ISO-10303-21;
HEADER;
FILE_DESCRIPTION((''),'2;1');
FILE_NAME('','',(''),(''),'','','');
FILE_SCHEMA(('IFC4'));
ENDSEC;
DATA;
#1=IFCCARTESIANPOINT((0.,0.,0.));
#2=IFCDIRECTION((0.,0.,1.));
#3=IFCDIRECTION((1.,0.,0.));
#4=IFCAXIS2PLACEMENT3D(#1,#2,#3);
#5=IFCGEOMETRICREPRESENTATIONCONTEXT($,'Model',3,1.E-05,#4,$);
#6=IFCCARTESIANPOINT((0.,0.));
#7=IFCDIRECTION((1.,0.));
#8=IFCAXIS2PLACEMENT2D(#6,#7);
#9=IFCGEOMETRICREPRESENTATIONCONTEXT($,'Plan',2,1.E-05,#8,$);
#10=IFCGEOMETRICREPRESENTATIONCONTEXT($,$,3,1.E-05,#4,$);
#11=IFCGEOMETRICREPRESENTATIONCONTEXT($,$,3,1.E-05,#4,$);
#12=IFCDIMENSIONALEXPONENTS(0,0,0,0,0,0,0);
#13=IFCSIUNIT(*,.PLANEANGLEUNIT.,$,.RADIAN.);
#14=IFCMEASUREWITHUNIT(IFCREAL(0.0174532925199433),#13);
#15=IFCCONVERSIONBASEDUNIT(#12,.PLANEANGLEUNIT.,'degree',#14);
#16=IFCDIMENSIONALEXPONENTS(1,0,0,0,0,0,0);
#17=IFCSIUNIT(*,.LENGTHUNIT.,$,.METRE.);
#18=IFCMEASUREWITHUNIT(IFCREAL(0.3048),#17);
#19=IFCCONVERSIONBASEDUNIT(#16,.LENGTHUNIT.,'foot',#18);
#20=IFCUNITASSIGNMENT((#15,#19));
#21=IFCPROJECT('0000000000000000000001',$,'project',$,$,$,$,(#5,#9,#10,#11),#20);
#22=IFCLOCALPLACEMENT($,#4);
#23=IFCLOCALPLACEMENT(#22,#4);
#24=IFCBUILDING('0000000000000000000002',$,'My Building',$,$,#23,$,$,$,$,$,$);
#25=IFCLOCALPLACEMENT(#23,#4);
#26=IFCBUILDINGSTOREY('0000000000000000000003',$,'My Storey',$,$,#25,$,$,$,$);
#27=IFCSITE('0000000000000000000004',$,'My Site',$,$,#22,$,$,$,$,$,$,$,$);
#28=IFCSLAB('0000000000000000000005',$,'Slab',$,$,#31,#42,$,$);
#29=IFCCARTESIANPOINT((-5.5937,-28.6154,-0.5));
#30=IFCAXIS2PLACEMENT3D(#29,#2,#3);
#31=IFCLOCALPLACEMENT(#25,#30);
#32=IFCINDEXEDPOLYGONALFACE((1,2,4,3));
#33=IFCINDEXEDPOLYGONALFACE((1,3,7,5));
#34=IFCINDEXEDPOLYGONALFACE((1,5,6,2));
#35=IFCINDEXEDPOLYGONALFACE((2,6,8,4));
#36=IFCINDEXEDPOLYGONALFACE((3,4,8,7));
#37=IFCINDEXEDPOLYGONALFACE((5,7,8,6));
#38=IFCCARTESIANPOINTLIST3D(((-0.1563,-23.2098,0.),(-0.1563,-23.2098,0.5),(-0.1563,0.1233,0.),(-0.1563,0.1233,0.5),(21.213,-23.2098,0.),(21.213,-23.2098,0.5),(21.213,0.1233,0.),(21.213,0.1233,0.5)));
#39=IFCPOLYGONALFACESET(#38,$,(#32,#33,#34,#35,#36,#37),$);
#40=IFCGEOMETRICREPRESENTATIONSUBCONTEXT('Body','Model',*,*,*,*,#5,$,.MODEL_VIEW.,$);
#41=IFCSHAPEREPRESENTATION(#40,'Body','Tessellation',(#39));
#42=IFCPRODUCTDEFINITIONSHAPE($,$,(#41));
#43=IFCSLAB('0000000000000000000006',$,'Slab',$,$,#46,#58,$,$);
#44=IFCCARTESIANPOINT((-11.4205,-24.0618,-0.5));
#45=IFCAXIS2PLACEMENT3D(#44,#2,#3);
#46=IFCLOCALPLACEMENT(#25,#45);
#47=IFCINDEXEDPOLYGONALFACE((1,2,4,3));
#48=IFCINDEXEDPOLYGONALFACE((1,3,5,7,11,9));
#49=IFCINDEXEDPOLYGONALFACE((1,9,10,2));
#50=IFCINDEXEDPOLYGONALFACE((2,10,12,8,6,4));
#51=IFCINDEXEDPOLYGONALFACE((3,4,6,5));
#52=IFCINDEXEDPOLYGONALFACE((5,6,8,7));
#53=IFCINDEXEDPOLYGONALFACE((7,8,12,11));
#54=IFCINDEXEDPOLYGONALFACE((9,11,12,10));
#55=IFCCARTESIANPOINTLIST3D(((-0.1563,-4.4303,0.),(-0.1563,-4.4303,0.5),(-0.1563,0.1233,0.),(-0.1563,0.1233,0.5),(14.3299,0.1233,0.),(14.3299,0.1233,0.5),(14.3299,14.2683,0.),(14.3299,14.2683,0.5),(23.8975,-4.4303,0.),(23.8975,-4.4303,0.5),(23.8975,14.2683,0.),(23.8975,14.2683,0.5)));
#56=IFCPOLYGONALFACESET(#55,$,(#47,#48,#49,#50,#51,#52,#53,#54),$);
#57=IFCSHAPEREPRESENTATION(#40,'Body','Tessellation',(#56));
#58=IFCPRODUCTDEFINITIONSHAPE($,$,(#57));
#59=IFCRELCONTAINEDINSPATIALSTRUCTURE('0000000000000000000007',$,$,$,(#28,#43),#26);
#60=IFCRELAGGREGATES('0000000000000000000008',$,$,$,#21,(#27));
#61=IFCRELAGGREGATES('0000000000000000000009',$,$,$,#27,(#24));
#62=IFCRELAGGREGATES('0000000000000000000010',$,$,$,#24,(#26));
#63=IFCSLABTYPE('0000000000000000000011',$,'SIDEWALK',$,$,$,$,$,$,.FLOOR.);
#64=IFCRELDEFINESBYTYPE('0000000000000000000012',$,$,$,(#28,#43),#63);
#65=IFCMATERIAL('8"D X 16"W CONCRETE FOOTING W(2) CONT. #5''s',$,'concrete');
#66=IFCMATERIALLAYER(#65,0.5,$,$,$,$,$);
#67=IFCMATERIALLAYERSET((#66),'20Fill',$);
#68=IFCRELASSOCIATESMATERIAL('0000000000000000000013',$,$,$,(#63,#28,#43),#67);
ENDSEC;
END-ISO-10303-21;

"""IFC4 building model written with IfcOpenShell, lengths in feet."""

from ifc_helpers import new_model, entity, si_unit, converted_unit, frame, origin_with_axes, origin_2d_with_axis, place, context, subcontext, project, spatial, line, indexed_curve, outline, extrude, material, layer, layer_set, layer_usage, type_object, element, save


model = new_model("IFC4")

# Units and contexts
model_context = context("Model", 3, precision=1e-05, world=origin_with_axes())
plan_context = context("Plan", 2, precision=1e-05, world=origin_2d_with_axis())
context_of_model_1 = context(None, 3, precision=1e-05, world=origin_with_axes())
context_of_model_2 = context(None, 3, precision=1e-05, world=origin_with_axes())
body_context = subcontext(model_context, "Body", "Model", "MODEL_VIEW")
ifc_project = project(units=[converted_unit("PLANEANGLEUNIT", "degree", entity("IfcReal", 0.0174532925199433), si_unit("PLANEANGLEUNIT", "RADIAN"), dimensions=[0, 0, 0, 0, 0, 0, 0]), converted_unit("LENGTHUNIT", "foot", entity("IfcReal", 0.3048), si_unit("LENGTHUNIT", "METRE"), dimensions=[1, 0, 0, 0, 0, 0, 0])], contexts=[model_context, plan_context, context_of_model_1, context_of_model_2])

# Site, building, storey
site_placement = place(None, origin_with_axes())
site = spatial("IfcSite", under=ifc_project, at=site_placement, Name="My Site")
building_placement = place(site_placement, origin_with_axes())
building = spatial("IfcBuilding", under=site, at=building_placement, Name="My Building")
storey_placement = place(building_placement, origin_with_axes())
storey = spatial("IfcBuildingStorey", under=building, at=storey_placement, Name="My Storey")

# Slabs
ifc_material_1 = material(Name="8\"D X 16\"W CONCRETE FOOTING W(2) CONT. #5's", Category="concrete")
ifc_layer_1 = layer(ifc_material_1, 0.5)
ifc_layer_set_1 = layer_set([ifc_layer_1], Name="20Fill")
ifc_layer_usage_1 = layer_usage(ifc_layer_set_1, "AXIS3", "POSITIVE", 0.0)
slab_type_1 = type_object("IfcSlabType", Name="SIDEWALK", PredefinedType="FLOOR", material=ifc_layer_set_1)
slab_1_placement = place(storey_placement, frame((-5.5937, -28.6154, -0.5), z_axis=(0.0, 0.0, 1.0), x_axis=(1.0, 0.0, 0.0)))
element("IfcSlab", 1, at=slab_1_placement, inside=storey, type_object=slab_type_1, material=ifc_layer_usage_1, Name="Slab", context=body_context, shape_type="SweptSolid", body=[
    extrude(outline(indexed_curve([(21.213, -23.2098), (21.213, 0.1233), (-0.1563, 0.1233), (-0.1563, -23.2098)], segments=[line(4, 1), line(1, 2), line(2, 3), line(3, 4)], self_intersect=False)), None, (0.0, 0.0, 1.0), 0.5),
])
ifc_layer_usage_2 = layer_usage(ifc_layer_set_1, "AXIS3", "POSITIVE", 0.0)
slab_2_placement = place(storey_placement, frame((-11.4205, -24.0618, -0.5), z_axis=(0.0, 0.0, 1.0), x_axis=(1.0, 0.0, 0.0)))
element("IfcSlab", 2, at=slab_2_placement, inside=storey, type_object=slab_type_1, material=ifc_layer_usage_2, Name="Slab", context=body_context, shape_type="SweptSolid", body=[
    extrude(outline(indexed_curve([(23.8975, 14.2683), (23.8975, -4.4303), (-0.1563, -4.4303), (-0.1563, 0.1233), (14.3299, 0.1233), (14.3299, 14.2683)], segments=[line(5, 4), line(4, 3), line(3, 2), line(2, 1), line(1, 6), line(6, 5)], self_intersect=False)), None, (0.0, 0.0, 1.0), 0.5),
])

save(model, "model.ifc")
